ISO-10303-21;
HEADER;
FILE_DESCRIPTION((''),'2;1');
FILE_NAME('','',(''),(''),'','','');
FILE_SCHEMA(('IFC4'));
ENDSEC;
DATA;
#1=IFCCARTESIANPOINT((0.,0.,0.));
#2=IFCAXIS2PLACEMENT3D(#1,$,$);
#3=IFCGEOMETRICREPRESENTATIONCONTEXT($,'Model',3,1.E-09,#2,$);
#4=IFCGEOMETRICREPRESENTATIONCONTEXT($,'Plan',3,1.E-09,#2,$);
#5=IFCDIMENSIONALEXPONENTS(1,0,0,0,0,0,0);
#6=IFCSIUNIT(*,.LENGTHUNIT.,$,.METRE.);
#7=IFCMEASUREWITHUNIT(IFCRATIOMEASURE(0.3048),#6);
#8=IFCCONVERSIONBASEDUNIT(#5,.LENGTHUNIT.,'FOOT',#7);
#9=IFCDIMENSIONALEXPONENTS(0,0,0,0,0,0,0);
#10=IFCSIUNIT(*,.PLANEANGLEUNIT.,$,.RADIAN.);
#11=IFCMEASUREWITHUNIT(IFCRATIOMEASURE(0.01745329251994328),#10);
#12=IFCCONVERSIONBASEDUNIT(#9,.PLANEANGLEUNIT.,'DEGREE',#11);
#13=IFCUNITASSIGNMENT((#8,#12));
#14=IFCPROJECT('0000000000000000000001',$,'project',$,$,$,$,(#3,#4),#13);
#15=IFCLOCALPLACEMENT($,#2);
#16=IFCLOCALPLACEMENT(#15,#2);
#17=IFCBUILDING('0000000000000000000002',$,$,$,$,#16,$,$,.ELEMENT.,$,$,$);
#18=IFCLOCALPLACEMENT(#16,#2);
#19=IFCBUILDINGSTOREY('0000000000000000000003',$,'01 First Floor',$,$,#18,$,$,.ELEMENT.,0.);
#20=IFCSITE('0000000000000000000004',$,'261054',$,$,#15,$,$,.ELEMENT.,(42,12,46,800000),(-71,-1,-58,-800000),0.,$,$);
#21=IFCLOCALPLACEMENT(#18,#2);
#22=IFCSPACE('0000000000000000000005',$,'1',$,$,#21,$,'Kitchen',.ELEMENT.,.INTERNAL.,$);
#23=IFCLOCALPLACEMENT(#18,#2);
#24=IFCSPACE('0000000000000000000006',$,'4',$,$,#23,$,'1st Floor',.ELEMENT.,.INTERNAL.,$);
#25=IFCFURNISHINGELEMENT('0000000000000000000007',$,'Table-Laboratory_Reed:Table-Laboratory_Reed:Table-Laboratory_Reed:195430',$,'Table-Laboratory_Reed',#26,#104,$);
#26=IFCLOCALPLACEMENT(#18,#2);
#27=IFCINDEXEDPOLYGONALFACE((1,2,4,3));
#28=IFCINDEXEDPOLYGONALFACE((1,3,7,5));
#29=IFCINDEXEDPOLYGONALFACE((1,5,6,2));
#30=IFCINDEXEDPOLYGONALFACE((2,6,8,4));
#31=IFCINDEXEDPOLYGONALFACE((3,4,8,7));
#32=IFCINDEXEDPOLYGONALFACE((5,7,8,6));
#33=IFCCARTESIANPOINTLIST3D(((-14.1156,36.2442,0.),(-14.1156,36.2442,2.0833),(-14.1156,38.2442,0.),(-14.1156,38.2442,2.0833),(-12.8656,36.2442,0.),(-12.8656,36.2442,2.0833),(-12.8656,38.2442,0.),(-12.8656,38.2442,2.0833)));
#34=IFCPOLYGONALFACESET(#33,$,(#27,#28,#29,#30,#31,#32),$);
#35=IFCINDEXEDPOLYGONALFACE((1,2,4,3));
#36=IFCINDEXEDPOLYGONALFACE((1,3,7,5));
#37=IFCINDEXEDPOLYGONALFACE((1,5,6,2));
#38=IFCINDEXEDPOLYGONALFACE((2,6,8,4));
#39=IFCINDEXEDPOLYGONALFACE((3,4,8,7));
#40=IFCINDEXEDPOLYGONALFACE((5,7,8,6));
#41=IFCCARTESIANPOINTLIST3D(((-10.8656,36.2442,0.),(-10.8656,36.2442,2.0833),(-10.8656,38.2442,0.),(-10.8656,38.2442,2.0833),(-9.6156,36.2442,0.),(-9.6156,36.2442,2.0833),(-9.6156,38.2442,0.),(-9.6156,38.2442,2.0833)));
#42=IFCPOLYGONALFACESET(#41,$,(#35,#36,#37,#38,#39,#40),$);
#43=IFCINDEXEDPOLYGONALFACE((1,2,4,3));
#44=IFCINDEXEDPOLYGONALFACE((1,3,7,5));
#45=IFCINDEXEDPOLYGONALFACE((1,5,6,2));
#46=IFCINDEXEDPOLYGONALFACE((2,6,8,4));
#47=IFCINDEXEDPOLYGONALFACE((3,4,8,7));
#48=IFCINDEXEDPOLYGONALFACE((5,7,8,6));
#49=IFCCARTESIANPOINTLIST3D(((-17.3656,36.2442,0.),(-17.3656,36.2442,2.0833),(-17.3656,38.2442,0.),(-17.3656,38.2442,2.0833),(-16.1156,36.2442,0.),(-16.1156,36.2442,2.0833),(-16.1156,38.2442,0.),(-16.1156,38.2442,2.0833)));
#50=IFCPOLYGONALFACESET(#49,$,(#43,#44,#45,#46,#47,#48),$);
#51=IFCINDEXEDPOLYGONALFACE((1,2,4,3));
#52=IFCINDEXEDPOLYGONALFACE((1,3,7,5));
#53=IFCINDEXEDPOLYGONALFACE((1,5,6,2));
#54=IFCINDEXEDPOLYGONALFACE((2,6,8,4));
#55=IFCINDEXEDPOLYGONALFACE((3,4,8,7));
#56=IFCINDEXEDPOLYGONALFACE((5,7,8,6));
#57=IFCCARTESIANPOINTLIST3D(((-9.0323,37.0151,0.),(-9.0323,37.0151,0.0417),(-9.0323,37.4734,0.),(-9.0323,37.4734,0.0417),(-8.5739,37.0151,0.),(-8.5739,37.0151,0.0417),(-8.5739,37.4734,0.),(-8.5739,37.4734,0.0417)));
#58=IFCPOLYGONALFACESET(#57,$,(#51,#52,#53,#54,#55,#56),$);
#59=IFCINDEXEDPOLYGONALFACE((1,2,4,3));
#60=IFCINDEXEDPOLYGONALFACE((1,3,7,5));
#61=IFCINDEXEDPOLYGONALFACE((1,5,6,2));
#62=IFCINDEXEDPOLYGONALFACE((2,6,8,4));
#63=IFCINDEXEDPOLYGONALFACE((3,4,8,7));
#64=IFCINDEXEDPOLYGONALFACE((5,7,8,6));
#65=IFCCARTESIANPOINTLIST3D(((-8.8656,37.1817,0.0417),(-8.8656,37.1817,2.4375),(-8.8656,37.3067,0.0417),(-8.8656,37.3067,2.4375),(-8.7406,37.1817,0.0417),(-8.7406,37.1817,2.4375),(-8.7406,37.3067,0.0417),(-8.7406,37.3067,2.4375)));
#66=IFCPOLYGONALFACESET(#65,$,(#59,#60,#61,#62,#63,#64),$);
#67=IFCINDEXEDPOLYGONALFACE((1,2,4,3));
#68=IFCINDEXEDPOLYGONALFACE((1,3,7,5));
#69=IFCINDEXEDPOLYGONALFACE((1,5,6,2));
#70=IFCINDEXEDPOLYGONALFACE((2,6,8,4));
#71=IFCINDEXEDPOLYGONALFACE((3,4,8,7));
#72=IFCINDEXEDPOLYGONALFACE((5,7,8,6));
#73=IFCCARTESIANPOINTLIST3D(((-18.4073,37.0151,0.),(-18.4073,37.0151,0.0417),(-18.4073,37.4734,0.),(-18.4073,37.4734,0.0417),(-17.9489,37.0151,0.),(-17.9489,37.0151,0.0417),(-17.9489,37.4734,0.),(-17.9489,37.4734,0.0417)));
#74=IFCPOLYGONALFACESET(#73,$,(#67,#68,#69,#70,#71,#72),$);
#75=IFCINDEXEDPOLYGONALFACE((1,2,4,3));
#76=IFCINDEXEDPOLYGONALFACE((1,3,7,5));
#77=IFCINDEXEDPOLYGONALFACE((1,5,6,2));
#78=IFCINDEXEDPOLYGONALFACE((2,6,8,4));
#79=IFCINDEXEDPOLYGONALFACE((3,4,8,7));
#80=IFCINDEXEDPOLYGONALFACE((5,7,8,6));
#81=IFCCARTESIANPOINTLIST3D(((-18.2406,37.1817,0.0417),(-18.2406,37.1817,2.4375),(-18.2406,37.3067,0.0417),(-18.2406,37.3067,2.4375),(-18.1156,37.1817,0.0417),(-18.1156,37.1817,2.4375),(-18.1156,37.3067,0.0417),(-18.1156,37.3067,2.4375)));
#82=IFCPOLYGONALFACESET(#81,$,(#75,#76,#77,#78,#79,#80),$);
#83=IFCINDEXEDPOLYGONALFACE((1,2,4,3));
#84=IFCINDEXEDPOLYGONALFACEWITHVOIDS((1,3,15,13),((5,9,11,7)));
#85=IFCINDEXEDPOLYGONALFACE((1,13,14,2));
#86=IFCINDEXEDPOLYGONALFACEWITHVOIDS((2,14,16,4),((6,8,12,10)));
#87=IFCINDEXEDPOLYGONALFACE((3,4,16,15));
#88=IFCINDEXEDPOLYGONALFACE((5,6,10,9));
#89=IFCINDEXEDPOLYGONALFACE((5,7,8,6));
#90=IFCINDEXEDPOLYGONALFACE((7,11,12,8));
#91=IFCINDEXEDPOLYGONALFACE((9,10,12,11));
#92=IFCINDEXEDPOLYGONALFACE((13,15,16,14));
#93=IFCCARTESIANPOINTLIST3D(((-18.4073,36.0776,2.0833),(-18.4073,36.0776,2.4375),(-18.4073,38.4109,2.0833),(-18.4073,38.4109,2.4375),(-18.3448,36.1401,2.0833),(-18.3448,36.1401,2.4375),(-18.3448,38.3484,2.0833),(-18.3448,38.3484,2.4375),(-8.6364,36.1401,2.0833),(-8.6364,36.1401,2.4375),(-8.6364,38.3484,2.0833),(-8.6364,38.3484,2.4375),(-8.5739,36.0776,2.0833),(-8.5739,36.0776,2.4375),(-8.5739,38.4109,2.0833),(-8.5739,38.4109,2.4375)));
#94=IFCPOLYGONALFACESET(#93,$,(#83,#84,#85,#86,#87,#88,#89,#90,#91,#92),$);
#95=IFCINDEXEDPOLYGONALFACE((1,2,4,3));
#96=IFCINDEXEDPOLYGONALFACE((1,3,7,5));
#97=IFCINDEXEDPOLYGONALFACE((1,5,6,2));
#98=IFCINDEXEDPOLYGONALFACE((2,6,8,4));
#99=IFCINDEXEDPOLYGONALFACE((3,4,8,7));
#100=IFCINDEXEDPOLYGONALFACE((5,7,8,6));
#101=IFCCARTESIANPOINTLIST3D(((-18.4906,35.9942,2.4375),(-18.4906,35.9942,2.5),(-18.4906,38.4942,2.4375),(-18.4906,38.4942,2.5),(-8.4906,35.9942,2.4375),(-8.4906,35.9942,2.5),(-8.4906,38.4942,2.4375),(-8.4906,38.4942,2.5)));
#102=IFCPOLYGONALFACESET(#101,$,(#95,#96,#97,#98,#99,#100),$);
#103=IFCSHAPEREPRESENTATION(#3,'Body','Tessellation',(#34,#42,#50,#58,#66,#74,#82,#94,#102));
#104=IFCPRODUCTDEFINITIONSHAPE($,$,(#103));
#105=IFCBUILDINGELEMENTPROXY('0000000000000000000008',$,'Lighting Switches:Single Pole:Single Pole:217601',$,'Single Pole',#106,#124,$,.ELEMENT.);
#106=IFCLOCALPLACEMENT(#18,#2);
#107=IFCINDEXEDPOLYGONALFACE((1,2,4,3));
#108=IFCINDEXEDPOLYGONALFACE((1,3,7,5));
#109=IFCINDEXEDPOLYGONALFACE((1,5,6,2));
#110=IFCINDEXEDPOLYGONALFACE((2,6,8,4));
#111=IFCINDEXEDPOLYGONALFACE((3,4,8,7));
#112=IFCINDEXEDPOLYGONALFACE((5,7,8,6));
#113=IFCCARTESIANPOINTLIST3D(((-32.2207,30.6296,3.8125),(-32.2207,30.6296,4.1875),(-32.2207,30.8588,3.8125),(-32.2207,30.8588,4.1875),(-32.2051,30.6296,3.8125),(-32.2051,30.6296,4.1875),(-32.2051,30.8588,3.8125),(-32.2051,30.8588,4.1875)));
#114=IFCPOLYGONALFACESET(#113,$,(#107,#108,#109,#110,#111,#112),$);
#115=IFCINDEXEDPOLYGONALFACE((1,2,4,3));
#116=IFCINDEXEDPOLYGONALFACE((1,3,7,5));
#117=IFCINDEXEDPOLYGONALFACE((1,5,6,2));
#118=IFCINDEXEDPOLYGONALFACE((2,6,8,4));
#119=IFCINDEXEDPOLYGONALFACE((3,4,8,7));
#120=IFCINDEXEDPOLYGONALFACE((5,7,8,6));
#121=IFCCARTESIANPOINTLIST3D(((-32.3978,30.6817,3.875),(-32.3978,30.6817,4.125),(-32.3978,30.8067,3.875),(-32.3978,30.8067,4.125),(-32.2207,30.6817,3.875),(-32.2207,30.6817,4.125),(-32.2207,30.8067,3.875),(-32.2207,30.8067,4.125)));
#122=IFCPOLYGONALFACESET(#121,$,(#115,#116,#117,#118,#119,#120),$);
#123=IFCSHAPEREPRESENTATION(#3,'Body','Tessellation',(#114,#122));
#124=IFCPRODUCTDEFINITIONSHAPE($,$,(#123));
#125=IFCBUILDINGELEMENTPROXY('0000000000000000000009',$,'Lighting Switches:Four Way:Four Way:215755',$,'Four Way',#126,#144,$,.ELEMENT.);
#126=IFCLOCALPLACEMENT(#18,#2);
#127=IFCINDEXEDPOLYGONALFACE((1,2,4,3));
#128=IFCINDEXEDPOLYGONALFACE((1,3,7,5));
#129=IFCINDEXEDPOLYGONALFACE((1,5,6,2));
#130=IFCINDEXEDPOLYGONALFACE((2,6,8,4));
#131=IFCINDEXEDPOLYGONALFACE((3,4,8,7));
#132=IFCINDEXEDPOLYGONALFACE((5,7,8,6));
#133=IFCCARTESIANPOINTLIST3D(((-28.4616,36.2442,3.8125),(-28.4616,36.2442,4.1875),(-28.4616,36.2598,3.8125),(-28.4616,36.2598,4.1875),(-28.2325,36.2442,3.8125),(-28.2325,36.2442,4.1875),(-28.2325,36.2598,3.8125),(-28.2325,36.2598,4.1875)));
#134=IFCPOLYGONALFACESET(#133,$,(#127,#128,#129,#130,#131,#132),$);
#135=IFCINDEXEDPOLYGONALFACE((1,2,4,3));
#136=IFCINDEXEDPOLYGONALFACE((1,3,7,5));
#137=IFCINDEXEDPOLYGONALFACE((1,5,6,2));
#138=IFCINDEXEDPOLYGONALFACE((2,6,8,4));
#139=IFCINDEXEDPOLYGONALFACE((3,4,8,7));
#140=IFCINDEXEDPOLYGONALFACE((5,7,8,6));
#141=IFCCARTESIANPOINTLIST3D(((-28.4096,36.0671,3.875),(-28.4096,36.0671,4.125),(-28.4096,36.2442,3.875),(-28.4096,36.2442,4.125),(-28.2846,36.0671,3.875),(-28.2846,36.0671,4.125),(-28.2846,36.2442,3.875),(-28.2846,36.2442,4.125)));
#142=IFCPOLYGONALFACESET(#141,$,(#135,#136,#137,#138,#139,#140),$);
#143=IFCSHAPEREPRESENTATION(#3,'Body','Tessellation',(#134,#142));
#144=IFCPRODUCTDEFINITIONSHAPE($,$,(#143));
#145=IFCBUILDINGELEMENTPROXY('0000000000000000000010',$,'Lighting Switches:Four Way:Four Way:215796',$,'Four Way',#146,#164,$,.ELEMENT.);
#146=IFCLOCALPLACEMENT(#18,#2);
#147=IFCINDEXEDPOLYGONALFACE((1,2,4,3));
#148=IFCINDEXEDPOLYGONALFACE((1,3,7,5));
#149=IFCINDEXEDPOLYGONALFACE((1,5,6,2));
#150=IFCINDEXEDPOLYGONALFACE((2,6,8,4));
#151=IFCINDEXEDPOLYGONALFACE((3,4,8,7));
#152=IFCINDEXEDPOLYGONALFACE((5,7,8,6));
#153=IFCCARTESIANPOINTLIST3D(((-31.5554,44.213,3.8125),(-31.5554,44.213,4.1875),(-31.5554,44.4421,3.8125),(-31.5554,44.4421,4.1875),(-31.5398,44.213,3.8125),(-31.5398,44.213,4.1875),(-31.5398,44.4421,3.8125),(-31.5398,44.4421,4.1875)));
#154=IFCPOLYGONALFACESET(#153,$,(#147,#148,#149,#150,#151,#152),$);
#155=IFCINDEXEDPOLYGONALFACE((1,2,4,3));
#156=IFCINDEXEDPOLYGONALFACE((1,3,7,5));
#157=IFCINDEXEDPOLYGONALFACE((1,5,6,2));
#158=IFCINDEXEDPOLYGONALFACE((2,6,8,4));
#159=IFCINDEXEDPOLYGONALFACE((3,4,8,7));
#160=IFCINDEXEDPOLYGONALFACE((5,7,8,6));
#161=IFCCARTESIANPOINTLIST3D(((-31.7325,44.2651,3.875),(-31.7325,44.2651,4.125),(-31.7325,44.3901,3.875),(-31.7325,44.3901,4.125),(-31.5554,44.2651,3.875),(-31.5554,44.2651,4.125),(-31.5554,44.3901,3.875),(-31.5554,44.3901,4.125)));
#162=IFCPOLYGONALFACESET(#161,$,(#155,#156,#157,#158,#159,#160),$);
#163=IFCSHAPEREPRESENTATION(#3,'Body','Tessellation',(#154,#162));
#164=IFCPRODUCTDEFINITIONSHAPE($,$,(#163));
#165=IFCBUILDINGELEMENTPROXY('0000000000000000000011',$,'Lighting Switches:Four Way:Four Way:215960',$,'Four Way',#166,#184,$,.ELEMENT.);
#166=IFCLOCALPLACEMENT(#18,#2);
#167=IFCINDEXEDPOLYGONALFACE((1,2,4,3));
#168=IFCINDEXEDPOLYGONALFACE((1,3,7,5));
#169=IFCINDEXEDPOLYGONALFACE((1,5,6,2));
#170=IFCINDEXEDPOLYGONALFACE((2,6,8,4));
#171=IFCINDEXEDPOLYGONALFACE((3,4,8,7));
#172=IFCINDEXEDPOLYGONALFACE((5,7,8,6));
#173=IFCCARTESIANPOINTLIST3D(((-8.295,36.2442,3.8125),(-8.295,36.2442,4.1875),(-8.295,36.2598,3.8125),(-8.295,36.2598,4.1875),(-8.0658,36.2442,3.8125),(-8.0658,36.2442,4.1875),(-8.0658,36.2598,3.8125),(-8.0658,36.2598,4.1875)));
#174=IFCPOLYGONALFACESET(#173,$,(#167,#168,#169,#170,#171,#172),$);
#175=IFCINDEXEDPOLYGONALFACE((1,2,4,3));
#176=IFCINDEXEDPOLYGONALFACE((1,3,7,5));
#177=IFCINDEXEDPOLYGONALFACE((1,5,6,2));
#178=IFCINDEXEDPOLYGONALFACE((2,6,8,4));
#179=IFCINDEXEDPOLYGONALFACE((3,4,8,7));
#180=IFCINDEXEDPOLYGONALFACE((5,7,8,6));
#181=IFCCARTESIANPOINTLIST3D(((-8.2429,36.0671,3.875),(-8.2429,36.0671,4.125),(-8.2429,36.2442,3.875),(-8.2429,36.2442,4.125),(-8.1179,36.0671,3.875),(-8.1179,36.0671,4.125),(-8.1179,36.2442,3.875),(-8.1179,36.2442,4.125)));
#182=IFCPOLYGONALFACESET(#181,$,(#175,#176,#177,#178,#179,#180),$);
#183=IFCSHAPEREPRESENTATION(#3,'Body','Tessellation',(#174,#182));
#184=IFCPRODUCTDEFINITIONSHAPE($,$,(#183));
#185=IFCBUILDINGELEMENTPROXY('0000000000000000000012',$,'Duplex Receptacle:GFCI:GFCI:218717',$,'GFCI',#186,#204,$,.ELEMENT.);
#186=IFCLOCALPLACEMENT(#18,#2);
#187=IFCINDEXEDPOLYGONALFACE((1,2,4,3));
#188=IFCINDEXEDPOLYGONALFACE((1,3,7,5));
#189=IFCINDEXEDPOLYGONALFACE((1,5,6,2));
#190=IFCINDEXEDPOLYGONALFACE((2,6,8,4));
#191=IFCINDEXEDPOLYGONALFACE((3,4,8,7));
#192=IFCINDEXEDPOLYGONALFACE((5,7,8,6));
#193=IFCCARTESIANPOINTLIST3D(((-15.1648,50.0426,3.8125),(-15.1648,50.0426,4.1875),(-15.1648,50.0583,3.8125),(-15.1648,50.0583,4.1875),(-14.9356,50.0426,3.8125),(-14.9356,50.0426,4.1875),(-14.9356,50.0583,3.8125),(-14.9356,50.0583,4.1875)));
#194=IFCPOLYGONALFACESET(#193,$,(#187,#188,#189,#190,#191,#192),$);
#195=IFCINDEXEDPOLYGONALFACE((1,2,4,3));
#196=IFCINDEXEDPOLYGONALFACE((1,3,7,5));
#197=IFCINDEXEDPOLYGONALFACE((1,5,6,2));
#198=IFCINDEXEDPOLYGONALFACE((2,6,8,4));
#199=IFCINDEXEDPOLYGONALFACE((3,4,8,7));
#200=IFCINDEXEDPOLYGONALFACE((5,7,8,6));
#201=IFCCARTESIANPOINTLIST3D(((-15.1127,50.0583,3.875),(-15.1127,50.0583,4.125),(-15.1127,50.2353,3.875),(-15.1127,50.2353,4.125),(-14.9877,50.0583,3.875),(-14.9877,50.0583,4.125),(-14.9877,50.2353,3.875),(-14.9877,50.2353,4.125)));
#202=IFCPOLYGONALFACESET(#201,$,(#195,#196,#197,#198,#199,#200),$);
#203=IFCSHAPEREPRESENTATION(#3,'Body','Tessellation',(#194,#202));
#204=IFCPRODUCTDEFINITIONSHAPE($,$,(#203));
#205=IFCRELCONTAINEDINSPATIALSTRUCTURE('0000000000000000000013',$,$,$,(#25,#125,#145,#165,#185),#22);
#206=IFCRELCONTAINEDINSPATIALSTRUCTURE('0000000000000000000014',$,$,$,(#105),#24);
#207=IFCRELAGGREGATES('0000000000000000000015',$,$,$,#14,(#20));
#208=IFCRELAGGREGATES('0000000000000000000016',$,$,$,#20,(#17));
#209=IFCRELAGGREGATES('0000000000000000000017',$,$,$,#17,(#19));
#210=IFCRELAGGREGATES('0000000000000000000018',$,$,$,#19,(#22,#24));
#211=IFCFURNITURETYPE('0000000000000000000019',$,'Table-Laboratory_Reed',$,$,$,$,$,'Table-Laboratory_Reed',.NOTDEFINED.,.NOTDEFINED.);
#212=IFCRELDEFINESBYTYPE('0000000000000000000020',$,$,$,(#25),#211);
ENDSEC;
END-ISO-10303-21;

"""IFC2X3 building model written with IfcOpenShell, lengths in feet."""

from ifc_helpers import new_model, entity, si_unit, converted_unit, frame, origin, origin_2d_with_axis, place, context, project, spatial, polyline, rectangle, outline, extrude, source, transform, mapped, type_object, type_shapes, element, save


model = new_model("IFC2X3")

# Units and contexts
model_context = context("Model", 3, precision=1e-09, world=origin())
plan_context = context("Plan", 3, precision=1e-09, world=origin())
ifc_project = project(units=[converted_unit("LENGTHUNIT", "FOOT", entity("IfcRatioMeasure", 0.3048), si_unit("LENGTHUNIT", "METRE"), dimensions=[1, 0, 0, 0, 0, 0, 0]), converted_unit("PLANEANGLEUNIT", "DEGREE", entity("IfcRatioMeasure", 0.01745329251994328), si_unit("PLANEANGLEUNIT", "RADIAN"), dimensions=[0, 0, 0, 0, 0, 0, 0])], contexts=[model_context, plan_context])

# Site, building, storey
site_placement = place(None, origin())
site = spatial("IfcSite", under=ifc_project, at=site_placement, Name="261054", CompositionType="ELEMENT", RefLatitude=(42, 12, 46, 800000), RefLongitude=(-71, -1, -58, -800000), RefElevation=0.0)
building_placement = place(site_placement, origin())
building = spatial("IfcBuilding", under=site, at=building_placement, CompositionType="ELEMENT")
storey_placement = place(building_placement, origin())
storey = spatial("IfcBuildingStorey", under=building, at=storey_placement, Name="01 First Floor", CompositionType="ELEMENT", Elevation=0.0)

# Shared definitions
space_1_placement = place(storey_placement, origin())
space_1 = spatial("IfcSpace", under=storey, at=space_1_placement, Name="1", LongName="Kitchen", CompositionType="ELEMENT", InteriorOrExteriorSpace="INTERNAL")

# Furnishing element
furniture_type = type_object("IfcFurnitureType", Name="Table-Laboratory_Reed", ElementType="Table-Laboratory_Reed", AssemblyPlace="NOTDEFINED")
shared_shape_1 = source(origin(), model_context, "Body", "SweptSolid", [
    extrude(rectangle(XDim=1.25, YDim=2.0, at=origin_2d_with_axis()), frame((-0.3333, 0.0, 0.0), z_axis=(0.0, 0.0, 1.0), x_axis=(-1.0, 0.0, 0.0)), (0.0, 0.0, 1.0), 2.0833),
    extrude(rectangle(XDim=1.25, YDim=2.0, at=origin_2d_with_axis()), frame((2.9167, 0.0, 0.0), z_axis=(0.0, 0.0, 1.0), x_axis=(-1.0, 0.0, 0.0)), (0.0, 0.0, 1.0), 2.0833),
    extrude(rectangle(XDim=1.25, YDim=2.0, at=origin_2d_with_axis()), frame((-3.5833, 0.0, 0.0), z_axis=(0.0, 0.0, 1.0), x_axis=(-1.0, 0.0, 0.0)), (0.0, 0.0, 1.0), 2.0833),
    extrude(rectangle(XDim=0.4583, YDim=0.4583, at=origin_2d_with_axis()), frame((4.3542, 0.0, 0.0), z_axis=(0.0, 0.0, 1.0), x_axis=(-1.0, 0.0, 0.0)), (0.0, 0.0, 1.0), 0.0417),
    extrude(rectangle(XDim=0.125, YDim=0.125, at=origin_2d_with_axis()), frame((4.3542, 0.0, 0.0417), z_axis=(0.0, 0.0, 1.0), x_axis=(-1.0, 0.0, 0.0)), (0.0, 0.0, 1.0), 2.3958),
    extrude(rectangle(XDim=0.4583, YDim=0.4583, at=origin_2d_with_axis()), frame((-5.0208, 0.0, 0.0), z_axis=(0.0, 0.0, 1.0), x_axis=(-1.0, 0.0, 0.0)), (0.0, 0.0, 1.0), 0.0417),
    extrude(rectangle(XDim=0.125, YDim=0.125, at=origin_2d_with_axis()), frame((-5.0208, 0.0, 0.0417), z_axis=(0.0, 0.0, 1.0), x_axis=(-1.0, 0.0, 0.0)), (0.0, 0.0, 1.0), 2.3958),
    extrude(outline(polyline([(-4.9167, -1.1667), (4.9167, -1.1667), (4.9167, 1.1667), (-4.9167, 1.1667), (-4.9167, -1.1667)]), holes=[polyline([(-4.8542, -1.1042), (-4.8542, 1.1042), (4.8542, 1.1042), (4.8542, -1.1042), (-4.8542, -1.1042)])]), frame((-0.3333, 0.0, 2.0833), z_axis=(0.0, 0.0, 1.0), x_axis=(-1.0, 0.0, 0.0)), (0.0, 0.0, 1.0), 0.3542),
    extrude(rectangle(XDim=10.0, YDim=2.5, at=origin_2d_with_axis()), frame((-0.3333, 0.0, 2.4375), z_axis=(0.0, 0.0, 1.0), x_axis=(-1.0, 0.0, 0.0)), (0.0, 0.0, 1.0), 0.0625),
])
type_shapes(furniture_type, [shared_shape_1])
for number, where, name in (
    (1, (-13.1573, 37.2442, 0.0), "Table-Laboratory_Reed:Table-Laboratory_Reed:Table-Laboratory_Reed:195430"),
):
    element("IfcFurnishingElement", number, at=place(space_1_placement, frame(where)), inside=space_1, type_object=furniture_type, Name=name, ObjectType="Table-Laboratory_Reed", context=model_context, shape_type="MappedRepresentation", body=[
        mapped(shared_shape_1, transform((0.0, 0.0, 0.0), scale=1.0)),
    ])

# Shared definitions
space_2_placement = place(storey_placement, origin())
space_2 = spatial("IfcSpace", under=storey, at=space_2_placement, Name="4", LongName="1st Floor", CompositionType="ELEMENT", InteriorOrExteriorSpace="INTERNAL")

# Building element proxies
shared_shape_2 = source(origin(), model_context, "Body", "SweptSolid", [
    extrude(rectangle(XDim=0.2292, YDim=0.375, at=origin_2d_with_axis()), frame((0.0, 0.0, 0.0), z_axis=(0.0, 0.0, 1.0), x_axis=(-1.0, 0.0, 0.0)), (0.0, 0.0, 1.0), 0.0156),
    extrude(rectangle(XDim=0.125, YDim=0.25, at=origin_2d_with_axis()), frame((0.0, 0.0, -0.1771), z_axis=(0.0, 0.0, 1.0), x_axis=(-1.0, 0.0, 0.0)), (0.0, 0.0, 1.0), 0.1771),
])
proxy_1_placement = place(space_2_placement, frame((-32.2207, 30.7442, 4.0), z_axis=(1.0, 0.0, 0.0), x_axis=(0.0, 1.0, 0.0)))
element("IfcBuildingElementProxy", 2, at=proxy_1_placement, inside=space_2, Name="Lighting Switches:Single Pole:Single Pole:217601", ObjectType="Single Pole", CompositionType="ELEMENT", context=model_context, shape_type="MappedRepresentation", body=[
    mapped(shared_shape_2, transform((0.0, 0.0, 0.0), scale=1.0)),
])
shared_shape_3 = source(origin(), model_context, "Body", "SweptSolid", [
    extrude(rectangle(XDim=0.2292, YDim=0.375, at=origin_2d_with_axis()), frame((0.0, 0.0, 0.0), z_axis=(0.0, 0.0, 1.0), x_axis=(-1.0, 0.0, 0.0)), (0.0, 0.0, 1.0), 0.0156),
    extrude(rectangle(XDim=0.125, YDim=0.25, at=origin_2d_with_axis()), frame((0.0, 0.0, -0.1771), z_axis=(0.0, 0.0, 1.0), x_axis=(-1.0, 0.0, 0.0)), (0.0, 0.0, 1.0), 0.1771),
])
for number, where, z_axis, x_axis, name in (
    (3, (-28.3471, 36.2442, 4.0), (0.0, 1.0, 0.0), (-1.0, 0.0, 0.0), "Lighting Switches:Four Way:Four Way:215755"),
    (4, (-31.5554, 44.3276, 4.0), (1.0, 0.0, 0.0), (0.0, 1.0, 0.0), "Lighting Switches:Four Way:Four Way:215796"),
    (5, (-8.1804, 36.2442, 4.0), (0.0, 1.0, 0.0), (-1.0, 0.0, 0.0), "Lighting Switches:Four Way:Four Way:215960"),
):
    element("IfcBuildingElementProxy", number, at=place(space_1_placement, frame(where, z_axis=z_axis, x_axis=x_axis)), inside=space_1, Name=name, ObjectType="Four Way", CompositionType="ELEMENT", context=model_context, shape_type="MappedRepresentation", body=[
        mapped(shared_shape_3, transform((0.0, 0.0, 0.0), scale=1.0)),
    ])
shared_shape_4 = source(origin(), model_context, "Body", "SweptSolid", [
    extrude(rectangle(XDim=0.2292, YDim=0.375, at=origin_2d_with_axis()), frame((0.0, 0.0, 0.0), z_axis=(0.0, 0.0, 1.0), x_axis=(-1.0, 0.0, 0.0)), (0.0, 0.0, 1.0), 0.0156),
    extrude(rectangle(XDim=0.125, YDim=0.25, at=origin_2d_with_axis()), frame((0.0, 0.0, -0.1771), z_axis=(0.0, 0.0, 1.0), x_axis=(-1.0, 0.0, 0.0)), (0.0, 0.0, 1.0), 0.1771),
])
for number, where, z_axis, x_axis, name in (
    (6, (-15.0502, 50.0583, 4.0), (0.0, -1.0, 0.0), (1.0, 0.0, 0.0), "Duplex Receptacle:GFCI:GFCI:218717"),
):
    element("IfcBuildingElementProxy", number, at=place(space_1_placement, frame(where, z_axis=z_axis, x_axis=x_axis)), inside=space_1, Name=name, ObjectType="GFCI", CompositionType="ELEMENT", context=model_context, shape_type="MappedRepresentation", body=[
        mapped(shared_shape_4, transform((0.0, 0.0, 0.0), scale=1.0)),
    ])

save(model, "model.ifc")
